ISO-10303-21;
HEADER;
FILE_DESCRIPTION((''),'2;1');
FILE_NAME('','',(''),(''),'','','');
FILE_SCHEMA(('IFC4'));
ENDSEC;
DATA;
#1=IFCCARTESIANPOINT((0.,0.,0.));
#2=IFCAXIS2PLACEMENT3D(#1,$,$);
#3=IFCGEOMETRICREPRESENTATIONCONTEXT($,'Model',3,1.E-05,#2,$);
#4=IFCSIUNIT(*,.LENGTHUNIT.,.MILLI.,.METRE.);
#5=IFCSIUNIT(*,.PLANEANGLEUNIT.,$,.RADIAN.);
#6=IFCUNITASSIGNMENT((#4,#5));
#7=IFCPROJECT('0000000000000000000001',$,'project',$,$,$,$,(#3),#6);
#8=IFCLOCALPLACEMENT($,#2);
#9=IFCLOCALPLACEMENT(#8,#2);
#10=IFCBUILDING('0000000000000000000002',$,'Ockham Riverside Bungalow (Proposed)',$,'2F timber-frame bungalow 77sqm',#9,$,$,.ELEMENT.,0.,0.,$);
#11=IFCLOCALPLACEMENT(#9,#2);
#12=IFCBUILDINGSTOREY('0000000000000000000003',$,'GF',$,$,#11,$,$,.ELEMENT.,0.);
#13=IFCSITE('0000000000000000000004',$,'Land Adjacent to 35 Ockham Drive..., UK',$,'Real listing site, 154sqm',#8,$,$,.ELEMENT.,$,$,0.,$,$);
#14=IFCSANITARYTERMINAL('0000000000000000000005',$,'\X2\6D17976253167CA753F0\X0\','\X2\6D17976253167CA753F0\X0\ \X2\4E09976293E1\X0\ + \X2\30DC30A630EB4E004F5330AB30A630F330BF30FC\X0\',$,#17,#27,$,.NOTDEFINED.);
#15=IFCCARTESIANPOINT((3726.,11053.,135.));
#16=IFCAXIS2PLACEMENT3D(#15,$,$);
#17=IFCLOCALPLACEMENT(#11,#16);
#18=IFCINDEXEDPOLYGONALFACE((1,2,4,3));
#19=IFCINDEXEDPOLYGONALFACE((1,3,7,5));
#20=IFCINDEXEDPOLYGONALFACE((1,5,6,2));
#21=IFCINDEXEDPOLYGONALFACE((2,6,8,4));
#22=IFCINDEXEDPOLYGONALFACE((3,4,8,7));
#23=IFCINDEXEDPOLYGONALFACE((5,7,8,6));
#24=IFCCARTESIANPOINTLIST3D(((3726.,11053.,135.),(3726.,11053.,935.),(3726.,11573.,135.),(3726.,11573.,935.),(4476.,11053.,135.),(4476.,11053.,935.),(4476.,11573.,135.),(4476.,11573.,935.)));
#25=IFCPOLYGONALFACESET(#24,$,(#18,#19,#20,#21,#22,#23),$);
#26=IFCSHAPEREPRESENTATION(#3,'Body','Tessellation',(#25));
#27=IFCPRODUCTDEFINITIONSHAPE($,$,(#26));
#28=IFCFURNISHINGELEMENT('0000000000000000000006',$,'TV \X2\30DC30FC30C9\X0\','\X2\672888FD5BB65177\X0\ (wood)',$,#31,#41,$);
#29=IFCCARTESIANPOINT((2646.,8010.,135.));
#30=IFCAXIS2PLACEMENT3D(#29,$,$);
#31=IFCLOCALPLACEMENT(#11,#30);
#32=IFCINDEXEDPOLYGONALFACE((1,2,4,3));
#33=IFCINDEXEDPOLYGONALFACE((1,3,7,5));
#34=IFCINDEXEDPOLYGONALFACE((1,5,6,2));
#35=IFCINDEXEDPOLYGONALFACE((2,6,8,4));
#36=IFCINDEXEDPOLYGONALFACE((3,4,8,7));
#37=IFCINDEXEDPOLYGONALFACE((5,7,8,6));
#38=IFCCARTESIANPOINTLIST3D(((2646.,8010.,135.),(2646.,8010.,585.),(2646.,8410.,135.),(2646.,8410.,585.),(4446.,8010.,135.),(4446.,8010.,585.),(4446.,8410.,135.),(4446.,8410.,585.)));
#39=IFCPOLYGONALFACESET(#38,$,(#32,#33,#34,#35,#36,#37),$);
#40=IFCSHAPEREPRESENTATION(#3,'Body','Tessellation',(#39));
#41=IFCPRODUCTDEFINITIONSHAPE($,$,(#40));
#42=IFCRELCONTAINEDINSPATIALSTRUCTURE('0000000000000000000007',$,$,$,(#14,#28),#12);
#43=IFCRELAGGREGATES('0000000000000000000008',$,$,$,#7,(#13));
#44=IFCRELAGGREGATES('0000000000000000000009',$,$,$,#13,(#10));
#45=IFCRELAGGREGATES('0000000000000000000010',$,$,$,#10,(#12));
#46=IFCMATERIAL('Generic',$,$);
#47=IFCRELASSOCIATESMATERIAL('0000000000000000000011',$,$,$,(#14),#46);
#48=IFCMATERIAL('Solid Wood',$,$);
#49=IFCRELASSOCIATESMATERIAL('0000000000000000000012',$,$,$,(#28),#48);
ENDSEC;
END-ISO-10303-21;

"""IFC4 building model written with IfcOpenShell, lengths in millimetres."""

from ifc_helpers import new_model, si_unit, frame, frame_2d, origin, place, context, project, spatial, rectangle, extrude, material, element, save


model = new_model("IFC4")

# Units and contexts
model_context = context("Model", 3, precision=1e-05, world=origin())
ifc_project = project(units=[si_unit("LENGTHUNIT", "METRE", prefix="MILLI"), si_unit("PLANEANGLEUNIT", "RADIAN")], contexts=[model_context])

# Site, building, storey
site_placement = place(None, origin())
site = spatial("IfcSite", under=ifc_project, at=site_placement, Name="Land Adjacent to 35 Ockham Drive..., UK", ObjectType="Real listing site, 154sqm", CompositionType="ELEMENT", RefElevation=0.0)
building_placement = place(site_placement, origin())
building = spatial("IfcBuilding", under=site, at=building_placement, Name="Ockham Riverside Bungalow (Proposed)", ObjectType="2F timber-frame bungalow 77sqm", CompositionType="ELEMENT", ElevationOfRefHeight=0.0, ElevationOfTerrain=0.0)
storey_placement = place(building_placement, origin())
storey = spatial("IfcBuildingStorey", under=building, at=storey_placement, Name="GF", CompositionType="ELEMENT", Elevation=0.0)

# Shared definitions
ifc_material_1 = material(Name="Solid Wood")

# Shared definitions
ifc_material_2 = material(Name="Generic")

# Sanitary terminal
sanitary_terminal_1_placement = place(storey_placement, frame((3726.0, 11053.0, 135.0)))
element("IfcSanitaryTerminal", 1, at=sanitary_terminal_1_placement, inside=storey, material=ifc_material_2, Name="洗面化粧台", Description="洗面化粧台 三面鏡 + ボウル一体カウンター", PredefinedType="NOTDEFINED", context=model_context, shape_type="SweptSolid", body=[
    extrude(rectangle(XDim=750.0, YDim=520.0, at=frame_2d((375.0, 260.0))), frame((3726.0, 11053.0, 135.0)), (0.0, 0.0, 1.0), 800.0),
])

# Furnishing element
furnishing_placement = place(storey_placement, frame((2646.0, 8010.0, 135.0)))
element("IfcFurnishingElement", 2, at=furnishing_placement, inside=storey, material=ifc_material_1, Name="TV ボード", Description="木製家具 (wood)", context=model_context, shape_type="SweptSolid", body=[
    extrude(rectangle(XDim=1800.0, YDim=400.0, at=frame_2d((900.0, 200.0))), frame((2646.0, 8010.0, 135.0)), (0.0, 0.0, 1.0), 450.0),
])

save(model, "model.ifc")
